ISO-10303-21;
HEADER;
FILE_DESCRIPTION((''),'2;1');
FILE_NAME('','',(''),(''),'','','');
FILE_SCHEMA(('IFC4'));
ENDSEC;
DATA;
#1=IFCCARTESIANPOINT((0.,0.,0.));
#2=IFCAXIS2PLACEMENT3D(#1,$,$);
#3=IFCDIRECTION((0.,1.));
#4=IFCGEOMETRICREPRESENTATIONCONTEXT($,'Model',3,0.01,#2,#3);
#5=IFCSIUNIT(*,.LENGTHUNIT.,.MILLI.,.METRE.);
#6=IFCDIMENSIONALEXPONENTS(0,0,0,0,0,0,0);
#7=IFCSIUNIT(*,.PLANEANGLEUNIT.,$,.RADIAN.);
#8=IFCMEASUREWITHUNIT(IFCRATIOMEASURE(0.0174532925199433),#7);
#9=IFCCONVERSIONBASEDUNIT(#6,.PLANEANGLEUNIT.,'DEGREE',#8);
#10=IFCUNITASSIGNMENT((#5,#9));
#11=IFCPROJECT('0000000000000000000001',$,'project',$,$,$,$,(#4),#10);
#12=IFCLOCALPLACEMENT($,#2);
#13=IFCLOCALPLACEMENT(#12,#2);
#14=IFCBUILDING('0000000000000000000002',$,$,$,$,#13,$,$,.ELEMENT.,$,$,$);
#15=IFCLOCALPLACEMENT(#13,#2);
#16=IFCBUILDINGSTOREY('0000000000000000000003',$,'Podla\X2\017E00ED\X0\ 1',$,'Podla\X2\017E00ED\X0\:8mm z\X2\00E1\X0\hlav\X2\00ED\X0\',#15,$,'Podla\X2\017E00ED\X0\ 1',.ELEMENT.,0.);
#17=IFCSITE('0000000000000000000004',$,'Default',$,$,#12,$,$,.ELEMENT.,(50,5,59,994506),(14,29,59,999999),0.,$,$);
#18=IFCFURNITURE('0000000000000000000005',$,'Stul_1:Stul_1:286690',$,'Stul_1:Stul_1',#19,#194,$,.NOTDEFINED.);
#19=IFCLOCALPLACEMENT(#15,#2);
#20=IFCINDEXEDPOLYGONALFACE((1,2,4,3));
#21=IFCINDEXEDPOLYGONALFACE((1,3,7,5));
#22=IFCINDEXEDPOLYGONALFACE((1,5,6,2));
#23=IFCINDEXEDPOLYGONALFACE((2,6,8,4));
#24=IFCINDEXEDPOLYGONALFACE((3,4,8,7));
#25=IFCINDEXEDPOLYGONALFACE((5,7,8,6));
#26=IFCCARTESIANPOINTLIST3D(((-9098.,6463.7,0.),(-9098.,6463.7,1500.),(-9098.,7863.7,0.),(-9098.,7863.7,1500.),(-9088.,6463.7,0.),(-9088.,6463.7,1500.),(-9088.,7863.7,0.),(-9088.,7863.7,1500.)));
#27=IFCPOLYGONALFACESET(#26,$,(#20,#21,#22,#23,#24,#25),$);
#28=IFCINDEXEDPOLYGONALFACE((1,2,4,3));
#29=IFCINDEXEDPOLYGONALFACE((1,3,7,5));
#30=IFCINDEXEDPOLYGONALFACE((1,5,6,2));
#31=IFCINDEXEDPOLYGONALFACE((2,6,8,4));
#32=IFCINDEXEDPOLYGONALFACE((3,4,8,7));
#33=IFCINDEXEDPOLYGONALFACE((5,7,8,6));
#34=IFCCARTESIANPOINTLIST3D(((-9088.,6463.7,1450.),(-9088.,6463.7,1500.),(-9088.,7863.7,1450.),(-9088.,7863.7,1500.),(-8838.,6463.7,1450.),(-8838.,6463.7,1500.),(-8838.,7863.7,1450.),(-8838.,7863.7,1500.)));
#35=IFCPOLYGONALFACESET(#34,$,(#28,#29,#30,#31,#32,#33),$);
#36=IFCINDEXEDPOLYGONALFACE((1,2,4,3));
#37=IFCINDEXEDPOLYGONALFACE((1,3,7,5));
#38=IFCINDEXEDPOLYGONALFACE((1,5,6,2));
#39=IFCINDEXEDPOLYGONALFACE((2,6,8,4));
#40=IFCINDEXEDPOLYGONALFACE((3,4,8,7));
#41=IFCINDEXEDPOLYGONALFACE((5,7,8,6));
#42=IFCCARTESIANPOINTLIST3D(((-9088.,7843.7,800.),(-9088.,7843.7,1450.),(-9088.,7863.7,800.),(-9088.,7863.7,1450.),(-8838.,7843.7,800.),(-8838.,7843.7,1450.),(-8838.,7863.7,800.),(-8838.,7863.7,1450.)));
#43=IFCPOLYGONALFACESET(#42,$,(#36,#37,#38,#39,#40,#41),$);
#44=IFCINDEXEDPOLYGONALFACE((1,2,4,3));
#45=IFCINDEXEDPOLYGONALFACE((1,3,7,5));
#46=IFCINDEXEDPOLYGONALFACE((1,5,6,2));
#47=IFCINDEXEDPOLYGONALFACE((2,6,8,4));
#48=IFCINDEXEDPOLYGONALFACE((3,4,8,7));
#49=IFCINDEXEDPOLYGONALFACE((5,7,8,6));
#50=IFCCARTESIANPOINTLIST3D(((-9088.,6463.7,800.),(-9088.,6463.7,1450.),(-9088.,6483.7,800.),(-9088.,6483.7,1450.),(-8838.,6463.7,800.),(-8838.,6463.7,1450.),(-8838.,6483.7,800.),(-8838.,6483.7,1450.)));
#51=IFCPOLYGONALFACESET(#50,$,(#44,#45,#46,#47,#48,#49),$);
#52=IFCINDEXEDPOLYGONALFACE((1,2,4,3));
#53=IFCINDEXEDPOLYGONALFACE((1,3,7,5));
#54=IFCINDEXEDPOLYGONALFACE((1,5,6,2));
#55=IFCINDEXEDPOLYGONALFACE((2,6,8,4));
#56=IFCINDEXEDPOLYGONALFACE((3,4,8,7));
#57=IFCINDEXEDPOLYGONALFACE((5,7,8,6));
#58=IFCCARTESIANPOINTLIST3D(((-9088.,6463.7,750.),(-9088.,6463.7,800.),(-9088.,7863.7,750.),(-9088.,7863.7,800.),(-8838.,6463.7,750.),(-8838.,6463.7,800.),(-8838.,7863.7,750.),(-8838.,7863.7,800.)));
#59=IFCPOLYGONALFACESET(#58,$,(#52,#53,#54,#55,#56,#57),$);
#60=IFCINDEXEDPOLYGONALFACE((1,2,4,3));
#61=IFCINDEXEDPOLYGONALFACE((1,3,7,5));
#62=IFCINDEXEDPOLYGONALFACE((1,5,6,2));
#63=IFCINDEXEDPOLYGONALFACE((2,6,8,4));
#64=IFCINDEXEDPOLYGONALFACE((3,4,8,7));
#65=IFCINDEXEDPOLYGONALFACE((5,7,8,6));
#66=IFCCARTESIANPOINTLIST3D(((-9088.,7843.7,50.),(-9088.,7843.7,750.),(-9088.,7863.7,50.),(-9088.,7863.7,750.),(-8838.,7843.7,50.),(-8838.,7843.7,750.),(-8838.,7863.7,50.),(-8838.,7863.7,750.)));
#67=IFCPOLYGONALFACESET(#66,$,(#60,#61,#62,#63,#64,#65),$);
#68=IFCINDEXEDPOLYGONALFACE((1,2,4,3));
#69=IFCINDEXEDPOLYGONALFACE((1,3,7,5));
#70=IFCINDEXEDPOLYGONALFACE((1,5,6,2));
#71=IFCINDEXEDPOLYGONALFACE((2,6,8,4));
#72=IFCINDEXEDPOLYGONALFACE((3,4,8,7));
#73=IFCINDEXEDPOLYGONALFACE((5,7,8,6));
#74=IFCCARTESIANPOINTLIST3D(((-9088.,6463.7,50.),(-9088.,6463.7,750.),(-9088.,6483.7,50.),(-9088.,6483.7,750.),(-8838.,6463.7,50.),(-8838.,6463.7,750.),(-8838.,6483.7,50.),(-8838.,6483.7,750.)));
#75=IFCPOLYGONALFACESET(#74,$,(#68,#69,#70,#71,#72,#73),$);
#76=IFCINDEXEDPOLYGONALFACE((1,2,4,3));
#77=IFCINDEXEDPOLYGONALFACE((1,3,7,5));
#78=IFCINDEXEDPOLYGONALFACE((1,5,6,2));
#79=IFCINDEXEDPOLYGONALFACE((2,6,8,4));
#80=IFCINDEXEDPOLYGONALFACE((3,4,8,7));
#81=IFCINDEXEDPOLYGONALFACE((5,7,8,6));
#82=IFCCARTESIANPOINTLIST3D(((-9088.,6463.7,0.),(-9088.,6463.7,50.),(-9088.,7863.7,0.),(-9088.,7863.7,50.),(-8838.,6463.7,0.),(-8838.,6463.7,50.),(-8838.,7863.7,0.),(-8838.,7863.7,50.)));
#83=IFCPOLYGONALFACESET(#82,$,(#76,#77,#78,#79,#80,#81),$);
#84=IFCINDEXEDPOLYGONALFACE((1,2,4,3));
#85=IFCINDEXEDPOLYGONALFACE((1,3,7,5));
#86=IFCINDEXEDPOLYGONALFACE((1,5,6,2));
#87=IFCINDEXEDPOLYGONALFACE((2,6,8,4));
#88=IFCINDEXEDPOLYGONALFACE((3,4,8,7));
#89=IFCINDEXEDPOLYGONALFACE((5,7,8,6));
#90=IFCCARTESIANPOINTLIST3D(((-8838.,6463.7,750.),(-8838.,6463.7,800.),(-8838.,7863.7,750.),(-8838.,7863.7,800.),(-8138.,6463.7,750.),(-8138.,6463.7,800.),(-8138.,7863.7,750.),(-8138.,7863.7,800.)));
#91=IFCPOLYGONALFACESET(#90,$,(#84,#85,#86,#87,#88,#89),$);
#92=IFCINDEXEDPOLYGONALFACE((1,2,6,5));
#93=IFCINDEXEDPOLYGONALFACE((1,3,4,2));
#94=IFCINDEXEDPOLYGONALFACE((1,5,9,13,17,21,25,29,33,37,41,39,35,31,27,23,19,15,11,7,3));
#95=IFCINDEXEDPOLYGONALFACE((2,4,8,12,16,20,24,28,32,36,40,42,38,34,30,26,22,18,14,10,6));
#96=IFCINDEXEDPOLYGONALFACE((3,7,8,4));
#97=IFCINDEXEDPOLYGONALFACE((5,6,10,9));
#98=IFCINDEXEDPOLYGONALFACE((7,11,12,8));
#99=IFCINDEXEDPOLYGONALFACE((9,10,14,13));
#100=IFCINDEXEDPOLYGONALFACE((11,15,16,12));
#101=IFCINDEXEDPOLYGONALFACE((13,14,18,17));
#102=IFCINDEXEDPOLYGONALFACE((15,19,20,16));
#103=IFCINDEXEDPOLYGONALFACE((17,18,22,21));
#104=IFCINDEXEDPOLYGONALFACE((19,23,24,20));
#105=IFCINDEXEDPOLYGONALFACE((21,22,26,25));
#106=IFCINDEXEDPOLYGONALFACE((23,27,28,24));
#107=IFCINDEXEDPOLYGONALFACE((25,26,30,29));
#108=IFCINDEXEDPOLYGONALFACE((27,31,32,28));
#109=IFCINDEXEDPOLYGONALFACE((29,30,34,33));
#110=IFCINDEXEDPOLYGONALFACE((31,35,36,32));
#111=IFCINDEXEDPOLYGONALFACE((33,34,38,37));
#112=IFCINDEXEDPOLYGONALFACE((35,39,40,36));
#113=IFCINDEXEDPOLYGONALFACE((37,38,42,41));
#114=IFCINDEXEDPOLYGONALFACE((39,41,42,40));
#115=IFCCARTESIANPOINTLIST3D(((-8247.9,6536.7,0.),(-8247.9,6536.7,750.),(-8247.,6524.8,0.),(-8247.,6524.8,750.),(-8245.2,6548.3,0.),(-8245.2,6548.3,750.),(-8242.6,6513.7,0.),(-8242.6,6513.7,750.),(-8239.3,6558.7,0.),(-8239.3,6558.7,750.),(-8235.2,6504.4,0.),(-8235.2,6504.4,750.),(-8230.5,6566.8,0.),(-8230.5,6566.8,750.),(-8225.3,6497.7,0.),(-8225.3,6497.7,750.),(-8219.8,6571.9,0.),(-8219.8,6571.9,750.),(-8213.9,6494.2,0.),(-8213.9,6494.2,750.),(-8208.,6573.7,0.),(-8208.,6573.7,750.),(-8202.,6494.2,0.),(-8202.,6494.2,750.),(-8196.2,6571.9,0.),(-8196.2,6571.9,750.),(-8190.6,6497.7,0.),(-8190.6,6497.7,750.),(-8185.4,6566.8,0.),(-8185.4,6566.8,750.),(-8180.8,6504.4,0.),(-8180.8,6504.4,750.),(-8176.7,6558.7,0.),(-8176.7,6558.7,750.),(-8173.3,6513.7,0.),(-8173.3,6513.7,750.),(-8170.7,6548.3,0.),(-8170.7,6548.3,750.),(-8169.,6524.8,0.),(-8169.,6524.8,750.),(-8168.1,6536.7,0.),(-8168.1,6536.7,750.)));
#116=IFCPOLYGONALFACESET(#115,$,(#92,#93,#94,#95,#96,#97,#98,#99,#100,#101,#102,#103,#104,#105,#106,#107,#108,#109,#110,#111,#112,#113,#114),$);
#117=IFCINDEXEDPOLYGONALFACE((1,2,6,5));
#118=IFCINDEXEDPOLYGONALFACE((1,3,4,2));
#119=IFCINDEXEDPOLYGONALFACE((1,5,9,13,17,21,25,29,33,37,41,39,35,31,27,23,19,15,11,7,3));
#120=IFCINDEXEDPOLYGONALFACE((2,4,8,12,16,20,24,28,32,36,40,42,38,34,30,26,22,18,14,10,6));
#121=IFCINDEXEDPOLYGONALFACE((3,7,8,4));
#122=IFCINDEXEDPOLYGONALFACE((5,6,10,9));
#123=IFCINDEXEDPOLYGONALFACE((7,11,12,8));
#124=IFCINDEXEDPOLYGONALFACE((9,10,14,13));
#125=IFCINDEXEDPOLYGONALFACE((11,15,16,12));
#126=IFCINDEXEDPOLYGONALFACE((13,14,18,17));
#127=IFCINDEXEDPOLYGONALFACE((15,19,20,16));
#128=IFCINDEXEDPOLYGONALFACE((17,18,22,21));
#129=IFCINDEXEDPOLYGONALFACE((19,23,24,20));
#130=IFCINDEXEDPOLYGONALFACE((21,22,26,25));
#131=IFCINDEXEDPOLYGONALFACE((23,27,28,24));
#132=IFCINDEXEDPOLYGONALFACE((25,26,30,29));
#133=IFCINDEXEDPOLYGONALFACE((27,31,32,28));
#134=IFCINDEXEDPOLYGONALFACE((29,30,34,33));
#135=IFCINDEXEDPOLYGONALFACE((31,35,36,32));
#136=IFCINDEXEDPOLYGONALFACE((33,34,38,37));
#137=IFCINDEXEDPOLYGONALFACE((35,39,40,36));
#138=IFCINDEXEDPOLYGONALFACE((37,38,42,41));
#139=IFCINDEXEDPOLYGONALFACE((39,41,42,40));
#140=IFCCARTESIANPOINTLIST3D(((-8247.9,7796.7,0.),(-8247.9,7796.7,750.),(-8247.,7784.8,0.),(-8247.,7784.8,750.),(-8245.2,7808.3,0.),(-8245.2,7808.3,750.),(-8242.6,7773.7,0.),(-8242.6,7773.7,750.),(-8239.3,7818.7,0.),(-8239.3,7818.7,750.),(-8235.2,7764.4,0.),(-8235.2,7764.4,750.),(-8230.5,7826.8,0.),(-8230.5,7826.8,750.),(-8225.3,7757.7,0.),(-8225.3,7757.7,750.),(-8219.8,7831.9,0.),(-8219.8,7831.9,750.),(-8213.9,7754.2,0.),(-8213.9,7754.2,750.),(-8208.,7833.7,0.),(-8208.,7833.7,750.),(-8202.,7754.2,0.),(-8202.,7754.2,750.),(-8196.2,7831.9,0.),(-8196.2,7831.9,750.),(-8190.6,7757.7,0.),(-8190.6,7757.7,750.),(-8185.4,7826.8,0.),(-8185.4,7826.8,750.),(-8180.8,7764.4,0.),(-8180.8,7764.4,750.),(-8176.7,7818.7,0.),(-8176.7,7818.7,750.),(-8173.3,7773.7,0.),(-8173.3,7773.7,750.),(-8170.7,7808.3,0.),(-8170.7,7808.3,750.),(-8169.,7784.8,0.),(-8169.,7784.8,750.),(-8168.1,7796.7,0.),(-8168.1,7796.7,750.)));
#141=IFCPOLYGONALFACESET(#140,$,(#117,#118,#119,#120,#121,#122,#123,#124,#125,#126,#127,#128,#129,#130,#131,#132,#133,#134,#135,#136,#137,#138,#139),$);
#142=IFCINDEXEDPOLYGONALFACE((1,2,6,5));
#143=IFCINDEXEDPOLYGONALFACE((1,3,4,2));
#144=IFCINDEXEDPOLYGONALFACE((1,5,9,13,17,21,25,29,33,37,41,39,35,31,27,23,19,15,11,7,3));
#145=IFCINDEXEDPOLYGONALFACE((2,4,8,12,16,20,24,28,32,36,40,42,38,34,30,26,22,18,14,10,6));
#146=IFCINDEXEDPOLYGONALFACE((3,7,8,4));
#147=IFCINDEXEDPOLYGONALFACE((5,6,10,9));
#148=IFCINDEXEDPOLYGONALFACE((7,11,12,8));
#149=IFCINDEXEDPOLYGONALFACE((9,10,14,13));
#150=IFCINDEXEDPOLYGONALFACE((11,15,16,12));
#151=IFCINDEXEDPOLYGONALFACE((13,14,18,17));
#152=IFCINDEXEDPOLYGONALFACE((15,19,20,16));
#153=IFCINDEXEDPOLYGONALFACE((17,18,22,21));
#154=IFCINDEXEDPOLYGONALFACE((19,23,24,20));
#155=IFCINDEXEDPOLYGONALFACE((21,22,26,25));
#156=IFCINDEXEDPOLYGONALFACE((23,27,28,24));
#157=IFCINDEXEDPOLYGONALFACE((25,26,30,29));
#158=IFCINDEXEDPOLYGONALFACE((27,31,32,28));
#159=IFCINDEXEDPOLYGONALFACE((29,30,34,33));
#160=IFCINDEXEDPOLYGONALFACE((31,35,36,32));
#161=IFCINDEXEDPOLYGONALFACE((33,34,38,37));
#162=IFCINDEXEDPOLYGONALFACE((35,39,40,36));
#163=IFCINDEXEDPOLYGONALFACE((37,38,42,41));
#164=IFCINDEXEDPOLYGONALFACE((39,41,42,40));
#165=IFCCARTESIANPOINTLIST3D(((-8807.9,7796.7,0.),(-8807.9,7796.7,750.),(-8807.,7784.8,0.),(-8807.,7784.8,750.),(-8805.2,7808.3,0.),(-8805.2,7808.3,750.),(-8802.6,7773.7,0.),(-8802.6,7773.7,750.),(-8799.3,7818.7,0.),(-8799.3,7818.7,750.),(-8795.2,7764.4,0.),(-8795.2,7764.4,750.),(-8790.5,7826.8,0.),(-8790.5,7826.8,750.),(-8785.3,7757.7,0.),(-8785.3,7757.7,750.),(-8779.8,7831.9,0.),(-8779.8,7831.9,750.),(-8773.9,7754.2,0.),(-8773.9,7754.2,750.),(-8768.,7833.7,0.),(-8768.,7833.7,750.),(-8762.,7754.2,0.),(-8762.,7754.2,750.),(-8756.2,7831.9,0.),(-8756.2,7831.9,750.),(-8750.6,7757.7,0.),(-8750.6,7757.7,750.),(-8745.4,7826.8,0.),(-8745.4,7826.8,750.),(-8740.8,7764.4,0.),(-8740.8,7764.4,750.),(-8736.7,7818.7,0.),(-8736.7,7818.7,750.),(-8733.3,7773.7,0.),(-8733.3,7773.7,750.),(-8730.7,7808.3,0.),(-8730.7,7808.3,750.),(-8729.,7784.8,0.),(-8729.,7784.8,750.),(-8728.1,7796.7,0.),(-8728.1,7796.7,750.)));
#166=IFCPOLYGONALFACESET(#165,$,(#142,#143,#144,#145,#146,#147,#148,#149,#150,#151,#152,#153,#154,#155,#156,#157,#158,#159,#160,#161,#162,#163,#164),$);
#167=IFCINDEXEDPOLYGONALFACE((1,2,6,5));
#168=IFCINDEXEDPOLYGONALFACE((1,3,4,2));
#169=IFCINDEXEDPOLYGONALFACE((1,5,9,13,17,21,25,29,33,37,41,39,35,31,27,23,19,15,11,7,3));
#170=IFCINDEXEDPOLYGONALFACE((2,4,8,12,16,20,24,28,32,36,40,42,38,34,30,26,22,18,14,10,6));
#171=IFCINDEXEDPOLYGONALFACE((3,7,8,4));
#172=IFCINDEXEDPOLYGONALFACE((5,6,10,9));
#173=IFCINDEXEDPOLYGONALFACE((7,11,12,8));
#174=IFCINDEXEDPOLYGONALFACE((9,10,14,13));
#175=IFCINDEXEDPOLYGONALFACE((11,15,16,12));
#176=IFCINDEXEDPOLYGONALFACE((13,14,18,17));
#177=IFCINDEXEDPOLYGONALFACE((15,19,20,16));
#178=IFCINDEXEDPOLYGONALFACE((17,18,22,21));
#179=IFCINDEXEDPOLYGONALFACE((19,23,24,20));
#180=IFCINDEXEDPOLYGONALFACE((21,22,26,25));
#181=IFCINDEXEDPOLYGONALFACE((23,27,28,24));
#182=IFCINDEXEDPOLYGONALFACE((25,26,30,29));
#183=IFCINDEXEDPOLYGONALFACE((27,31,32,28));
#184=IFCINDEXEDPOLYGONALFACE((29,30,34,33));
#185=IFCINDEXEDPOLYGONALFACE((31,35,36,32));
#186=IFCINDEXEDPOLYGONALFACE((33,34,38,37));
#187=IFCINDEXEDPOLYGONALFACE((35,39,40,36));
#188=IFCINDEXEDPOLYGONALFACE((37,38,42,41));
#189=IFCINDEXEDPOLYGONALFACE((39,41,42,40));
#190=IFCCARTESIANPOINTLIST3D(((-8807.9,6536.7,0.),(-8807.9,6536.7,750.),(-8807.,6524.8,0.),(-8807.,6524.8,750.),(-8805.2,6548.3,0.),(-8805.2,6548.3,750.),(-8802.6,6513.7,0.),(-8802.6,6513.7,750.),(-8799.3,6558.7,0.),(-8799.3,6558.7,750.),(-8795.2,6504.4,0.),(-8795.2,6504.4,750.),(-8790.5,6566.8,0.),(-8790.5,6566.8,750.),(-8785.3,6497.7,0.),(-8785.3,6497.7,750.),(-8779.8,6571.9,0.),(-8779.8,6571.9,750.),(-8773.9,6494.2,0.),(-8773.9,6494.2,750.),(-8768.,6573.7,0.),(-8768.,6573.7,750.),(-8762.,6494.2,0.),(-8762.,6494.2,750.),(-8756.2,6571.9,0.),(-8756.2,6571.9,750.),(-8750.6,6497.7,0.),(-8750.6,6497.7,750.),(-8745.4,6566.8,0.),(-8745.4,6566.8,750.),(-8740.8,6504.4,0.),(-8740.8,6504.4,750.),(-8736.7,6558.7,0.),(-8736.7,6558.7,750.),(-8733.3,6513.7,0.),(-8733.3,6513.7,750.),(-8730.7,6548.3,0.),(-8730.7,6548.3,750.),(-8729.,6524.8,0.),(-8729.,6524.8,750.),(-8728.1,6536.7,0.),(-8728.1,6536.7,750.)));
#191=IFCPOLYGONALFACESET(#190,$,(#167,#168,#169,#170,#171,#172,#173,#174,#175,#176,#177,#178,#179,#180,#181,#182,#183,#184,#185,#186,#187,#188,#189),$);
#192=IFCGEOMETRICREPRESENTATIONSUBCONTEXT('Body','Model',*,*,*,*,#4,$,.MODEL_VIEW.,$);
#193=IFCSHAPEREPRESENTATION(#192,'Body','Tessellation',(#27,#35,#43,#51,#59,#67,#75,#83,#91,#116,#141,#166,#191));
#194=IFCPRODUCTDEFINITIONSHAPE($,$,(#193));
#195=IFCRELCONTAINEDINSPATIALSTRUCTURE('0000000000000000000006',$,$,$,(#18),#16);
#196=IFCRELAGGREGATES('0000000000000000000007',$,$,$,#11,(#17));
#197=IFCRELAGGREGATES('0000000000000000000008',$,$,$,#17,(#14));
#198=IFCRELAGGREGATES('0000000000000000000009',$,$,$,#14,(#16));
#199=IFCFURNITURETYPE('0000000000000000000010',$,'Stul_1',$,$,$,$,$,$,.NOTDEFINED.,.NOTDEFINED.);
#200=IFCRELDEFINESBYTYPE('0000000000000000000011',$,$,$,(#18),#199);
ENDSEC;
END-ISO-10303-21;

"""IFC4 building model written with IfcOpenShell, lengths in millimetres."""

from ifc_helpers import new_model, entity, si_unit, converted_unit, direction, frame, frame_2d, origin, origin_2d_with_axis, place, context, subcontext, project, spatial, rectangle, circle, extrude, source, transform, mapped, type_object, type_shapes, element, save


model = new_model("IFC4")

# Units and contexts
model_context = context("Model", 3, precision=0.01, world=origin(), true_north=direction((0.0, 1.0)))
body_context = subcontext(model_context, "Body", "Model", "MODEL_VIEW")
ifc_project = project(units=[si_unit("LENGTHUNIT", "METRE", prefix="MILLI"), converted_unit("PLANEANGLEUNIT", "DEGREE", entity("IfcRatioMeasure", 0.0174532925199433), si_unit("PLANEANGLEUNIT", "RADIAN"), dimensions=[0, 0, 0, 0, 0, 0, 0])], contexts=[model_context])

# Site, building, storey
site_placement = place(None, origin())
site = spatial("IfcSite", under=ifc_project, at=site_placement, Name="Default", CompositionType="ELEMENT", RefLatitude=(50, 5, 59, 994506), RefLongitude=(14, 29, 59, 999999), RefElevation=0.0)
building_placement = place(site_placement, origin())
building = spatial("IfcBuilding", under=site, at=building_placement, CompositionType="ELEMENT")
storey_placement = place(building_placement, origin())
storey = spatial("IfcBuildingStorey", under=building, at=storey_placement, Name="Podlaží 1", ObjectType="Podlaží:8mm záhlaví", LongName="Podlaží 1", CompositionType="ELEMENT", Elevation=0.0)

# Furniture
furniture_type = type_object("IfcFurnitureType", Name="Stul_1", AssemblyPlace="NOTDEFINED", PredefinedType="NOTDEFINED")
shared_shape_1 = source(origin(), body_context, "Body", "SweptSolid", [
    extrude(rectangle(XDim=1400.0, YDim=10.0, at=origin_2d_with_axis()), frame((0.0, 605.0, 0.0), z_axis=(0.0, 0.0, 1.0), x_axis=(-1.0, 0.0, 0.0)), (0.0, 0.0, 1.0), 1500.0),
    extrude(rectangle(XDim=1400.0, YDim=250.0, at=frame_2d((0.0, 0.0), x_axis=(1.0, 0.0))), frame((0.0, 475.0, 1450.0), z_axis=(0.0, 0.0, 1.0), x_axis=(-1.0, 0.0, 0.0)), (0.0, 0.0, 1.0), 50.0),
    extrude(rectangle(XDim=20.0, YDim=250.0, at=origin_2d_with_axis()), frame((690.0, 475.0, 800.0), z_axis=(0.0, 0.0, 1.0), x_axis=(-1.0, 0.0, 0.0)), (0.0, 0.0, 1.0), 650.0),
    extrude(rectangle(XDim=20.0, YDim=250.0, at=frame_2d((0.0, 0.0), x_axis=(1.0, 0.0))), frame((-690.0, 475.0, 800.0), z_axis=(0.0, 0.0, 1.0), x_axis=(-1.0, 0.0, 0.0)), (0.0, 0.0, 1.0), 650.0),
    extrude(rectangle(XDim=1400.0, YDim=250.0, at=origin_2d_with_axis()), frame((0.0, 475.0, 750.0), z_axis=(0.0, 0.0, 1.0), x_axis=(-1.0, 0.0, 0.0)), (0.0, 0.0, 1.0), 50.0),
    extrude(rectangle(XDim=20.0, YDim=250.0, at=origin_2d_with_axis()), frame((690.0, 475.0, 50.0), z_axis=(0.0, 0.0, 1.0), x_axis=(-1.0, 0.0, 0.0)), (0.0, 0.0, 1.0), 700.0),
    extrude(rectangle(XDim=20.0, YDim=250.0, at=frame_2d((0.0, 0.0), x_axis=(1.0, 0.0))), frame((-690.0, 475.0, 50.0), z_axis=(0.0, 0.0, 1.0), x_axis=(-1.0, 0.0, 0.0)), (0.0, 0.0, 1.0), 700.0),
    extrude(rectangle(XDim=1400.0, YDim=250.0, at=origin_2d_with_axis()), frame((0.0, 475.0, 0.0), z_axis=(0.0, 0.0, 1.0), x_axis=(-1.0, 0.0, 0.0)), (0.0, 0.0, 1.0), 50.0),
    extrude(rectangle(XDim=1400.0, YDim=700.0, at=origin_2d_with_axis()), frame((0.0, 0.0, 750.0), z_axis=(0.0, 0.0, 1.0), x_axis=(-1.0, 0.0, 0.0)), (0.0, 0.0, 1.0), 50.0),
    extrude(circle(Radius=40.0, at=frame_2d((0.0, 0.0), x_axis=(1.0, 0.0))), frame((-630.0, -280.0, 0.0)), (0.0, 0.0, 1.0), 750.0),
    extrude(circle(Radius=40.0, at=frame_2d((0.0, 0.0), x_axis=(1.0, 0.0))), frame((630.0, -280.0, 0.0)), (0.0, 0.0, 1.0), 750.0),
    extrude(circle(Radius=40.0, at=frame_2d((0.0, 0.0), x_axis=(1.0, 0.0))), frame((630.0, 280.0, 0.0)), (0.0, 0.0, 1.0), 750.0),
    extrude(circle(Radius=40.0, at=frame_2d((0.0, 0.0), x_axis=(1.0, 0.0))), frame((-630.0, 280.0, 0.0)), (0.0, 0.0, 1.0), 750.0),
])
type_shapes(furniture_type, [shared_shape_1])
for number, where, z_axis, x_axis, name in (
    (1, (-8488.0, 7163.7, 0.0), (0.0, 0.0, 1.0), (0.0, 1.0, 0.0), "Stul_1:Stul_1:286690"),
):
    element("IfcFurniture", number, at=place(storey_placement, frame(where, z_axis=z_axis, x_axis=x_axis)), inside=storey, type_object=furniture_type, Name=name, ObjectType="Stul_1:Stul_1", PredefinedType="NOTDEFINED", context=body_context, shape_type="MappedRepresentation", body=[
        mapped(shared_shape_1, transform((0.0, 0.0, 0.0), scale=1.0)),
    ])

save(model, "model.ifc")
